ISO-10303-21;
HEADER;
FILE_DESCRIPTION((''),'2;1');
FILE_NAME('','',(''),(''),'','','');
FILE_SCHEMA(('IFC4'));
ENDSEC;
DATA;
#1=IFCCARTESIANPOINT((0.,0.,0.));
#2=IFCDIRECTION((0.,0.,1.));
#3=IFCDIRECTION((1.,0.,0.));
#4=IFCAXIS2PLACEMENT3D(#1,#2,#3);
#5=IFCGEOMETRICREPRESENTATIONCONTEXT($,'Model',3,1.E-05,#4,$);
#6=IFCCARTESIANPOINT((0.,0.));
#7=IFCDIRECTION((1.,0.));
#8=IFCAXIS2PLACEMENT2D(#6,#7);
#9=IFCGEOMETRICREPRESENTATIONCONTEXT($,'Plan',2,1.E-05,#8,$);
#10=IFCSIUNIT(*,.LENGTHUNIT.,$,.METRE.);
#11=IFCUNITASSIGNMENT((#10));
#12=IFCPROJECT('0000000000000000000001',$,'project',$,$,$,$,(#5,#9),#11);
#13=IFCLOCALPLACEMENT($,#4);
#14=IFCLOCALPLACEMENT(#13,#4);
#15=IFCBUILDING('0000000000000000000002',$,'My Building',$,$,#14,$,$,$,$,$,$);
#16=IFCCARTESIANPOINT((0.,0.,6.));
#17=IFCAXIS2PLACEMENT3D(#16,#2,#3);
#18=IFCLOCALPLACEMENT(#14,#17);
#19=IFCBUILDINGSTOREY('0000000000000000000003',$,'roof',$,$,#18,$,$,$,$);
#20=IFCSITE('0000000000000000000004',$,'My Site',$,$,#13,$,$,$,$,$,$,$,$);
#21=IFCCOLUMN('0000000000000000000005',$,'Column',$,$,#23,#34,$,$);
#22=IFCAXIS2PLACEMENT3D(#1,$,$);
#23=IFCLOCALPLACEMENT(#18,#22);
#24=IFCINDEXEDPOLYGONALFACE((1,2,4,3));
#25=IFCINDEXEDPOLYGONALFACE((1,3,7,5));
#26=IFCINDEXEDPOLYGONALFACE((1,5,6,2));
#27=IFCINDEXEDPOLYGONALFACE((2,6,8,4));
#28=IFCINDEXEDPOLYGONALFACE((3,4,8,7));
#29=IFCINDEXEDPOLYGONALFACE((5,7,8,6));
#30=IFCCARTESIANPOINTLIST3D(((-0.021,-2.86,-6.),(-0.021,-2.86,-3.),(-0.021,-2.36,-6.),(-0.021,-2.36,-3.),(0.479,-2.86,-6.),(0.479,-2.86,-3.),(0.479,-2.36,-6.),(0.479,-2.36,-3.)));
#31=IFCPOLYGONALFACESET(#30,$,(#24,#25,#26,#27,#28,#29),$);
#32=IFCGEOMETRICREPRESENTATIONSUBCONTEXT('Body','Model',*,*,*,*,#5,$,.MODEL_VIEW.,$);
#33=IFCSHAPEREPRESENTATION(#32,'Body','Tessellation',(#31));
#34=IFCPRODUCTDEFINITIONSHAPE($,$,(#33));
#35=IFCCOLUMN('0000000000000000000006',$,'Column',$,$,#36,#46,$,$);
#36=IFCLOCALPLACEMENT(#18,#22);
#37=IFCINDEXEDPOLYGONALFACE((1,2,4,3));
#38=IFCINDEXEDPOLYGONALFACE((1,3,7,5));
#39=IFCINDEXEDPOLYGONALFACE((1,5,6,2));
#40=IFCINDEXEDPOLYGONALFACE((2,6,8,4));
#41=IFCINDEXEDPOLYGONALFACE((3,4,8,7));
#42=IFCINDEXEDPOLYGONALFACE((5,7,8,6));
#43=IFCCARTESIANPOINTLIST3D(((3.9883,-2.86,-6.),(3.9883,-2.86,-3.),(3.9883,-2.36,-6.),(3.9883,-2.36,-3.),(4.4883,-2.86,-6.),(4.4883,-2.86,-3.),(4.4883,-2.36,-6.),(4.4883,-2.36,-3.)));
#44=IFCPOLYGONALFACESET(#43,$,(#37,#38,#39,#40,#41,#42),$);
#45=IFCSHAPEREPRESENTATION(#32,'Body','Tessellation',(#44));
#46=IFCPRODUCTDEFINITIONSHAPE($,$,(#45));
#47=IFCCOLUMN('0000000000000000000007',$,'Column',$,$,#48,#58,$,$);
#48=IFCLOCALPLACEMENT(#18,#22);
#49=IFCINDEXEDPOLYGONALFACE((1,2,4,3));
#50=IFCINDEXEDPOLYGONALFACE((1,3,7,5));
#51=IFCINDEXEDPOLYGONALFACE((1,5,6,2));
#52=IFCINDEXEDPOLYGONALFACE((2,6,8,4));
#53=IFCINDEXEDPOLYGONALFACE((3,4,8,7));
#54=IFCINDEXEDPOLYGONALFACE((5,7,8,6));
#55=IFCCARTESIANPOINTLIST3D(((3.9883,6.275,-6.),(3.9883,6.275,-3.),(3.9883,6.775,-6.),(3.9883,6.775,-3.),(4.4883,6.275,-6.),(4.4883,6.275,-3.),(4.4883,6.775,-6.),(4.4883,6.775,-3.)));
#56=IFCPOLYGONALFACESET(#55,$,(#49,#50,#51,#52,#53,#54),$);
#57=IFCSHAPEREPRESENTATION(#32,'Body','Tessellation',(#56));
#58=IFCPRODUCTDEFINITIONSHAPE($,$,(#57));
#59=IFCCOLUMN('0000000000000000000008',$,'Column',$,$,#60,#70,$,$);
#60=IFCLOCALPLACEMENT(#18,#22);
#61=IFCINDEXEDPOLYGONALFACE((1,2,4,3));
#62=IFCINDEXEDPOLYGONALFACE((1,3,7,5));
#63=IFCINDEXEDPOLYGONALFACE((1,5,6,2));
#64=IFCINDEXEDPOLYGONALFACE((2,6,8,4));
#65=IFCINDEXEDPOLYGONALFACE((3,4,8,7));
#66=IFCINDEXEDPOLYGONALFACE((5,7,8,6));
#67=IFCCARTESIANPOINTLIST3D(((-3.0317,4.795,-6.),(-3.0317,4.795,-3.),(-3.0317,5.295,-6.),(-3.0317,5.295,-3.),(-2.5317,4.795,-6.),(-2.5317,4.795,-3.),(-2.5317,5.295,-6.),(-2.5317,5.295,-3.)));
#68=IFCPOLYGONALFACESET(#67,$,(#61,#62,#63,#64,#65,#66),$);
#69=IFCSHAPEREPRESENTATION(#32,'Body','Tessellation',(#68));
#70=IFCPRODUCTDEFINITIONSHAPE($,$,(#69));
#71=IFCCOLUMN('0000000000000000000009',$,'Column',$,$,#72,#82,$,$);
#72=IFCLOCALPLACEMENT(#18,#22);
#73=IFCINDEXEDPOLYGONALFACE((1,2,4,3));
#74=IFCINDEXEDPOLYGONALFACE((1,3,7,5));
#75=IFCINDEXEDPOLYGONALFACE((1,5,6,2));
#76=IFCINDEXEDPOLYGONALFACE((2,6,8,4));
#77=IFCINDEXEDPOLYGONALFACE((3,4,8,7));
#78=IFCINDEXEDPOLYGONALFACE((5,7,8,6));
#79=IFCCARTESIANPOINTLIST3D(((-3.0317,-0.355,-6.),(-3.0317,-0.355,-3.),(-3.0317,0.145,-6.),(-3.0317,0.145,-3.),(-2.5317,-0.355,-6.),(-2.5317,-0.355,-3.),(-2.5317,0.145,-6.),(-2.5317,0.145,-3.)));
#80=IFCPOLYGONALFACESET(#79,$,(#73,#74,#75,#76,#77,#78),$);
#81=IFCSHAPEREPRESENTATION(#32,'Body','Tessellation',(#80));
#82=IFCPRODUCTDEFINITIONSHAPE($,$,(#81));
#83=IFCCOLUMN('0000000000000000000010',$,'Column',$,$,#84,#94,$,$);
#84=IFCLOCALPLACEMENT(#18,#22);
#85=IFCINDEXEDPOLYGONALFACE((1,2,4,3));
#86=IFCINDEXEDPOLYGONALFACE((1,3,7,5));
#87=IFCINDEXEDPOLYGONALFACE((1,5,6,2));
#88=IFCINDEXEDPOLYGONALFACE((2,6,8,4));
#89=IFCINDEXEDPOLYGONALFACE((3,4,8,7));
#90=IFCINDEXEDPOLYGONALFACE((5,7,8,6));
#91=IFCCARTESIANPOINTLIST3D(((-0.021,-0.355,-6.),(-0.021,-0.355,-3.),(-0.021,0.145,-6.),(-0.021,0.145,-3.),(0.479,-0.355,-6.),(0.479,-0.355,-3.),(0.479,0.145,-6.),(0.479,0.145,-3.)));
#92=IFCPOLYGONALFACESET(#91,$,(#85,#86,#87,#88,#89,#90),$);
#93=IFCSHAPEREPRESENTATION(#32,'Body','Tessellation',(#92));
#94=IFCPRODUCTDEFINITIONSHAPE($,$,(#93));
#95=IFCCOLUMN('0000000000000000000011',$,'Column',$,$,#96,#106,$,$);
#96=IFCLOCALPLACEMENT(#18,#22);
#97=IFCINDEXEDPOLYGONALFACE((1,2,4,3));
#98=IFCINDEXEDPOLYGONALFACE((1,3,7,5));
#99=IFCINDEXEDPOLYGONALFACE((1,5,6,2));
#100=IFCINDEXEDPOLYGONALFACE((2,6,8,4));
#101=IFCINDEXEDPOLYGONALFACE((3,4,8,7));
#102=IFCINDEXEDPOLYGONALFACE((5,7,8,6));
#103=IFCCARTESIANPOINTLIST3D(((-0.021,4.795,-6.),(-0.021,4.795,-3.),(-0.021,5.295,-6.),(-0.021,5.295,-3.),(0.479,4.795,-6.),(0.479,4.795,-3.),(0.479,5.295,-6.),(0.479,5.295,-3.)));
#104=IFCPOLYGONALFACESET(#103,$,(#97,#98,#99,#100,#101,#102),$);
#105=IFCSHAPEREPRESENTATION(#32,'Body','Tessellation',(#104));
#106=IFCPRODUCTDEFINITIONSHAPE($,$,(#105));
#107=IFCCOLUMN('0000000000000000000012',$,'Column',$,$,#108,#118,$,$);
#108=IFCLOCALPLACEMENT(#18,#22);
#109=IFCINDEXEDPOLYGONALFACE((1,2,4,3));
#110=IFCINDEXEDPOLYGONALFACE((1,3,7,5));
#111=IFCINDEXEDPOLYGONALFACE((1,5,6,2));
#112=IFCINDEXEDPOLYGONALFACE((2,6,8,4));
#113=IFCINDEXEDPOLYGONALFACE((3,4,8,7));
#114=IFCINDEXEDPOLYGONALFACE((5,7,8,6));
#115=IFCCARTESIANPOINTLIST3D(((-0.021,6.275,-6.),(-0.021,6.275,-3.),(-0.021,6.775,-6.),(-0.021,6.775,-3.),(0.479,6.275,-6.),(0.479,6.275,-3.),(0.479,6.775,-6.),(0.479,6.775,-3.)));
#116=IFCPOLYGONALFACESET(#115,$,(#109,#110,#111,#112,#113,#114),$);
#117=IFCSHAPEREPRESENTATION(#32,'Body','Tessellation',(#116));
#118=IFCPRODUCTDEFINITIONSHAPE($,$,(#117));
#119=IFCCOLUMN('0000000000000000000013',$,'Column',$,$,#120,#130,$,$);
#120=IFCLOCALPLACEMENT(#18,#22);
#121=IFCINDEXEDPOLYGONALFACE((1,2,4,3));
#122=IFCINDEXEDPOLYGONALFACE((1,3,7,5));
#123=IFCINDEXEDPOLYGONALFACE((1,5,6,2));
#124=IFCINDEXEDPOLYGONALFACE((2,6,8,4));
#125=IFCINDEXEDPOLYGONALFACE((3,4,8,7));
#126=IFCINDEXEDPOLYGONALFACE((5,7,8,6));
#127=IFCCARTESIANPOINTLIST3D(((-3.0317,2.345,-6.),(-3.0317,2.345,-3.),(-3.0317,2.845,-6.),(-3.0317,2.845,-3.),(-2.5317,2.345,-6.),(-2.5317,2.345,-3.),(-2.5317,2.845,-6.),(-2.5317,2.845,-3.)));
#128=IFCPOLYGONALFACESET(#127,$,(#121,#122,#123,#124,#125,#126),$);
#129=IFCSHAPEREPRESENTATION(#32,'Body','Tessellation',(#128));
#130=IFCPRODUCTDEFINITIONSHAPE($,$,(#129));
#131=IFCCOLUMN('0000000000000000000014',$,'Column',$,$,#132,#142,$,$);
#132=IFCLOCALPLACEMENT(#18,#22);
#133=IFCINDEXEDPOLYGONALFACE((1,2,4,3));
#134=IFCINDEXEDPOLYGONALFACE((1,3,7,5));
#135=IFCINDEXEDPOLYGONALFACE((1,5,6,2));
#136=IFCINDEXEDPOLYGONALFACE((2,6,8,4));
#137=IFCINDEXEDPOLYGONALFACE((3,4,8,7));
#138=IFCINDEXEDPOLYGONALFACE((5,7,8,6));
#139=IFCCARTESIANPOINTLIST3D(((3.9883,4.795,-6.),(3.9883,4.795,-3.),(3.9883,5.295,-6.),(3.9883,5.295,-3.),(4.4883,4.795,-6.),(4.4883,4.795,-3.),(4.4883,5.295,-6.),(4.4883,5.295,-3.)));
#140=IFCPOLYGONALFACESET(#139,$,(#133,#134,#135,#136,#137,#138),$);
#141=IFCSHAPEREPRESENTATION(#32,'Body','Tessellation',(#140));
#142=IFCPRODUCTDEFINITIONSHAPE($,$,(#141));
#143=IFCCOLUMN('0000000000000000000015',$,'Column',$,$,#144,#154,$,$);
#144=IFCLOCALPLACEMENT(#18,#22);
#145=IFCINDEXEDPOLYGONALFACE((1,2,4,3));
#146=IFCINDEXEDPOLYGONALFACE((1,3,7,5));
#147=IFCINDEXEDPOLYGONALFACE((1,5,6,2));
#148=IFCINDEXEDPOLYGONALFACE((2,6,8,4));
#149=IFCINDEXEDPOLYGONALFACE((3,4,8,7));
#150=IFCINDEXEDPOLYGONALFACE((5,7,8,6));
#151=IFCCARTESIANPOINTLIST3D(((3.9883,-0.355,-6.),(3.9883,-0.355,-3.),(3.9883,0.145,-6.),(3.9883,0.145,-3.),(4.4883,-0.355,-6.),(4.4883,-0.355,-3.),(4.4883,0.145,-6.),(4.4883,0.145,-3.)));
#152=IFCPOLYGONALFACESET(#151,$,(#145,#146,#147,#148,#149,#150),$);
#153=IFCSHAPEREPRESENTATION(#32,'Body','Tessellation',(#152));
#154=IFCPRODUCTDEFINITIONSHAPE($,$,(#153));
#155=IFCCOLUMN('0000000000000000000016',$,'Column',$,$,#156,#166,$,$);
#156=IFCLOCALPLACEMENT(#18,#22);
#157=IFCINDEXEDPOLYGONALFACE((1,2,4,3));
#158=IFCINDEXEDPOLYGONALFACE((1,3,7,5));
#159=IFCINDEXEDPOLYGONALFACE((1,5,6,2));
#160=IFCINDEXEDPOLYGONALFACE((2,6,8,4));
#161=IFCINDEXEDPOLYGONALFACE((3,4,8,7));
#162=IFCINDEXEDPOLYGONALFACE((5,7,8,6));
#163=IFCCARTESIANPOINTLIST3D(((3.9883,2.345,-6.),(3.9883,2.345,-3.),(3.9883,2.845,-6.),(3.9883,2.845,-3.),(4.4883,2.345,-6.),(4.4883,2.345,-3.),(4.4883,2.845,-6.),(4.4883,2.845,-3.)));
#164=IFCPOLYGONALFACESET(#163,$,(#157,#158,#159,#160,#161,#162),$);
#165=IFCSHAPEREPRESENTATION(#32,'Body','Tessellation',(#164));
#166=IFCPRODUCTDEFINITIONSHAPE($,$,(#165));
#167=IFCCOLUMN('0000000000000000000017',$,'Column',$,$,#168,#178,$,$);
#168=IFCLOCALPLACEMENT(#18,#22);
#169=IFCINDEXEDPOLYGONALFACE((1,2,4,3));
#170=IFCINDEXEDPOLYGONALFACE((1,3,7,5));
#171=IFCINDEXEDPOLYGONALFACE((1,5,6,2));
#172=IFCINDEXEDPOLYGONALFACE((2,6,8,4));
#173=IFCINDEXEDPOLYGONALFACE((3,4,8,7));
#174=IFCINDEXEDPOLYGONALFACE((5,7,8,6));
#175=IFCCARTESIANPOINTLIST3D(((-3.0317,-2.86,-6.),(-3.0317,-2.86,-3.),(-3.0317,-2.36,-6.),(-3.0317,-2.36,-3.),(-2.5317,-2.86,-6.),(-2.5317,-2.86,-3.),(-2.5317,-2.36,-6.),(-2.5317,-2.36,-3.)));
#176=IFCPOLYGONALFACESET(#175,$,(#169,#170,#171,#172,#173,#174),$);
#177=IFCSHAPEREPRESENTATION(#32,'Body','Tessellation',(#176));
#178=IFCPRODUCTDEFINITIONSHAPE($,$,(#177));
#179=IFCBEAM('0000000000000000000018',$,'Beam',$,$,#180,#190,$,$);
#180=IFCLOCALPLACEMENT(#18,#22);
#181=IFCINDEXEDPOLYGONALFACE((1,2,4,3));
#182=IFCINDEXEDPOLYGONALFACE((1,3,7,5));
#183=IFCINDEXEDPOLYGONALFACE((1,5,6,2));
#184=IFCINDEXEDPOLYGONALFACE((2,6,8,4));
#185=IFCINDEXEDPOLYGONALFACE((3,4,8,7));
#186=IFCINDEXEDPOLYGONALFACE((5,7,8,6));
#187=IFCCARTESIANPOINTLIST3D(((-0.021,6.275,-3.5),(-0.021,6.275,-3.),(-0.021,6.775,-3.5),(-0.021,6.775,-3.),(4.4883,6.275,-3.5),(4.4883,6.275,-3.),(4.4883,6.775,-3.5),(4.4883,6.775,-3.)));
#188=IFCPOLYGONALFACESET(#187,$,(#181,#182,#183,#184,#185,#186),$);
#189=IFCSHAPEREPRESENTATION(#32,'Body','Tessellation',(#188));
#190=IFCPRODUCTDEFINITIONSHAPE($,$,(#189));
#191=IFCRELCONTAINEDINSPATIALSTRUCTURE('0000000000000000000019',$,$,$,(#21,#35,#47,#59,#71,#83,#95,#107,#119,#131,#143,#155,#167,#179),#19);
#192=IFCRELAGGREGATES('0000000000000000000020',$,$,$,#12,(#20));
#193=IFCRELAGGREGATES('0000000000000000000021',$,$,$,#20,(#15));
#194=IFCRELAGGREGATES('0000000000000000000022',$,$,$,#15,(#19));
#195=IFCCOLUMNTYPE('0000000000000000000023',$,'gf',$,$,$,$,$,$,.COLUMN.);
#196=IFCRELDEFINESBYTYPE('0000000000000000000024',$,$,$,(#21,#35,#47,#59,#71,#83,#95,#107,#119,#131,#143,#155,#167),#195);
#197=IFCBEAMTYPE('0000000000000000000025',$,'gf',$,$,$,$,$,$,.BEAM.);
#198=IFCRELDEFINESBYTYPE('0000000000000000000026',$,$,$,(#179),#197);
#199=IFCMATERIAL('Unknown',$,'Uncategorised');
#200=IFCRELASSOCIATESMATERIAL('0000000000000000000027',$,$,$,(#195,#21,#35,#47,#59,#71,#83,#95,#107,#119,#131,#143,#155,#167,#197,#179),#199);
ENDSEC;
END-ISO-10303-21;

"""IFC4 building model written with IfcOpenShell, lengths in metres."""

from ifc_helpers import new_model, si_unit, frame, origin_with_axes, origin_2d_with_axis, place, context, subcontext, project, spatial, rectangle, extrude, material, material_profile, profile_set, profile_usage, type_object, element, save


model = new_model("IFC4")

# Units and contexts
model_context = context("Model", 3, precision=1e-05, world=origin_with_axes())
plan_context = context("Plan", 2, precision=1e-05, world=origin_2d_with_axis())
body_context = subcontext(model_context, "Body", "Model", "MODEL_VIEW")
ifc_project = project(units=[si_unit("LENGTHUNIT", "METRE")], contexts=[model_context, plan_context])

# Site, building, storey
site_placement = place(None, origin_with_axes())
site = spatial("IfcSite", under=ifc_project, at=site_placement, Name="My Site")
building_placement = place(site_placement, origin_with_axes())
building = spatial("IfcBuilding", under=site, at=building_placement, Name="My Building")
storey_placement = place(building_placement, frame((0.0, 0.0, 6.0), z_axis=(0.0, 0.0, 1.0), x_axis=(1.0, 0.0, 0.0)))
storey = spatial("IfcBuildingStorey", under=building, at=storey_placement, Name="roof")

# Columns
ifc_material = material(Name="Unknown", Category="Uncategorised")
ifc_material_profile_1 = material_profile(ifc_material, rectangle(XDim=0.5, YDim=0.5))
ifc_profile_set_1 = profile_set([ifc_material_profile_1])
ifc_profile_usage_1 = profile_usage(ifc_profile_set_1, cardinal=5)
column_type = type_object("IfcColumnType", Name="gf", PredefinedType="COLUMN", material=ifc_profile_set_1)
column_1_placement = place(storey_placement, frame((0.229, -2.61, -6.0), z_axis=(0.0, 0.0, 1.0), x_axis=(1.0, 0.0, 0.0)))
element("IfcColumn", 1, at=column_1_placement, inside=storey, type_object=column_type, material=ifc_profile_usage_1, Name="Column", context=body_context, shape_type="SweptSolid", body=[
    extrude(rectangle(XDim=0.5, YDim=0.5), origin_with_axes(), (0.0, 0.0, 1.0), 3.0),
])
ifc_profile_usage_2 = profile_usage(ifc_profile_set_1, cardinal=5)
column_2_placement = place(storey_placement, frame((4.2383, -2.61, -6.0), z_axis=(0.0, 0.0, 1.0), x_axis=(1.0, 0.0, 0.0)))
element("IfcColumn", 2, at=column_2_placement, inside=storey, type_object=column_type, material=ifc_profile_usage_2, Name="Column", context=body_context, shape_type="SweptSolid", body=[
    extrude(rectangle(XDim=0.5, YDim=0.5), origin_with_axes(), (0.0, 0.0, 1.0), 3.0),
])
ifc_profile_usage_3 = profile_usage(ifc_profile_set_1, cardinal=5)
column_3_placement = place(storey_placement, frame((4.2383, 6.525, -6.0), z_axis=(0.0, 0.0, 1.0), x_axis=(1.0, 0.0, 0.0)))
element("IfcColumn", 3, at=column_3_placement, inside=storey, type_object=column_type, material=ifc_profile_usage_3, Name="Column", context=body_context, shape_type="SweptSolid", body=[
    extrude(rectangle(XDim=0.5, YDim=0.5), origin_with_axes(), (0.0, 0.0, 1.0), 3.0),
])
ifc_profile_usage_4 = profile_usage(ifc_profile_set_1, cardinal=5)
column_4_placement = place(storey_placement, frame((-2.7817, 5.045, -6.0), z_axis=(0.0, 0.0, 1.0), x_axis=(1.0, 0.0, 0.0)))
element("IfcColumn", 4, at=column_4_placement, inside=storey, type_object=column_type, material=ifc_profile_usage_4, Name="Column", context=body_context, shape_type="SweptSolid", body=[
    extrude(rectangle(XDim=0.5, YDim=0.5), origin_with_axes(), (0.0, 0.0, 1.0), 3.0),
])
ifc_profile_usage_5 = profile_usage(ifc_profile_set_1, cardinal=5)
column_5_placement = place(storey_placement, frame((-2.7817, -0.105, -6.0), z_axis=(0.0, 0.0, 1.0), x_axis=(1.0, 0.0, 0.0)))
element("IfcColumn", 5, at=column_5_placement, inside=storey, type_object=column_type, material=ifc_profile_usage_5, Name="Column", context=body_context, shape_type="SweptSolid", body=[
    extrude(rectangle(XDim=0.5, YDim=0.5), origin_with_axes(), (0.0, 0.0, 1.0), 3.0),
])
ifc_profile_usage_6 = profile_usage(ifc_profile_set_1, cardinal=5)
column_6_placement = place(storey_placement, frame((0.229, -0.105, -6.0), z_axis=(0.0, 0.0, 1.0), x_axis=(1.0, 0.0, 0.0)))
element("IfcColumn", 6, at=column_6_placement, inside=storey, type_object=column_type, material=ifc_profile_usage_6, Name="Column", context=body_context, shape_type="SweptSolid", body=[
    extrude(rectangle(XDim=0.5, YDim=0.5), origin_with_axes(), (0.0, 0.0, 1.0), 3.0),
])
ifc_profile_usage_7 = profile_usage(ifc_profile_set_1, cardinal=5)
column_7_placement = place(storey_placement, frame((0.229, 5.045, -6.0), z_axis=(0.0, 0.0, 1.0), x_axis=(1.0, 0.0, 0.0)))
element("IfcColumn", 7, at=column_7_placement, inside=storey, type_object=column_type, material=ifc_profile_usage_7, Name="Column", context=body_context, shape_type="SweptSolid", body=[
    extrude(rectangle(XDim=0.5, YDim=0.5), origin_with_axes(), (0.0, 0.0, 1.0), 3.0),
])
ifc_profile_usage_8 = profile_usage(ifc_profile_set_1, cardinal=5)
column_8_placement = place(storey_placement, frame((0.229, 6.525, -6.0), z_axis=(0.0, 0.0, 1.0), x_axis=(1.0, 0.0, 0.0)))
element("IfcColumn", 8, at=column_8_placement, inside=storey, type_object=column_type, material=ifc_profile_usage_8, Name="Column", context=body_context, shape_type="SweptSolid", body=[
    extrude(rectangle(XDim=0.5, YDim=0.5), origin_with_axes(), (0.0, 0.0, 1.0), 3.0),
])
ifc_profile_usage_9 = profile_usage(ifc_profile_set_1, cardinal=5)
column_9_placement = place(storey_placement, frame((-2.7817, 2.595, -6.0), z_axis=(0.0, 0.0, 1.0), x_axis=(1.0, 0.0, 0.0)))
element("IfcColumn", 9, at=column_9_placement, inside=storey, type_object=column_type, material=ifc_profile_usage_9, Name="Column", context=body_context, shape_type="SweptSolid", body=[
    extrude(rectangle(XDim=0.5, YDim=0.5), origin_with_axes(), (0.0, 0.0, 1.0), 3.0),
])
ifc_profile_usage_10 = profile_usage(ifc_profile_set_1, cardinal=5)
column_10_placement = place(storey_placement, frame((4.2383, 5.045, -6.0), z_axis=(0.0, 0.0, 1.0), x_axis=(1.0, 0.0, 0.0)))
element("IfcColumn", 10, at=column_10_placement, inside=storey, type_object=column_type, material=ifc_profile_usage_10, Name="Column", context=body_context, shape_type="SweptSolid", body=[
    extrude(rectangle(XDim=0.5, YDim=0.5), origin_with_axes(), (0.0, 0.0, 1.0), 3.0),
])
ifc_profile_usage_11 = profile_usage(ifc_profile_set_1, cardinal=5)
column_11_placement = place(storey_placement, frame((4.2383, -0.105, -6.0), z_axis=(0.0, 0.0, 1.0), x_axis=(1.0, 0.0, 0.0)))
element("IfcColumn", 11, at=column_11_placement, inside=storey, type_object=column_type, material=ifc_profile_usage_11, Name="Column", context=body_context, shape_type="SweptSolid", body=[
    extrude(rectangle(XDim=0.5, YDim=0.5), origin_with_axes(), (0.0, 0.0, 1.0), 3.0),
])
ifc_profile_usage_12 = profile_usage(ifc_profile_set_1, cardinal=5)
column_12_placement = place(storey_placement, frame((4.2383, 2.595, -6.0), z_axis=(0.0, 0.0, 1.0), x_axis=(1.0, 0.0, 0.0)))
element("IfcColumn", 12, at=column_12_placement, inside=storey, type_object=column_type, material=ifc_profile_usage_12, Name="Column", context=body_context, shape_type="SweptSolid", body=[
    extrude(rectangle(XDim=0.5, YDim=0.5), origin_with_axes(), (0.0, 0.0, 1.0), 3.0),
])
ifc_profile_usage_13 = profile_usage(ifc_profile_set_1, cardinal=5)
column_13_placement = place(storey_placement, frame((-2.7817, -2.61, -6.0), z_axis=(0.0, 0.0, 1.0), x_axis=(1.0, 0.0, 0.0)))
element("IfcColumn", 13, at=column_13_placement, inside=storey, type_object=column_type, material=ifc_profile_usage_13, Name="Column", context=body_context, shape_type="SweptSolid", body=[
    extrude(rectangle(XDim=0.5, YDim=0.5), origin_with_axes(), (0.0, 0.0, 1.0), 3.0),
])

# Beam
ifc_material_profile_2 = material_profile(ifc_material, rectangle(XDim=0.5, YDim=0.5))
ifc_profile_set_2 = profile_set([ifc_material_profile_2])
ifc_profile_usage_14 = profile_usage(ifc_profile_set_2, cardinal=7)
beam_type = type_object("IfcBeamType", Name="gf", PredefinedType="BEAM", material=ifc_profile_set_2)
beam_1_placement = place(storey_placement, frame((-0.021, 6.775, -3.0), z_axis=(1.0, -0.000001, 0.000001), x_axis=(0.000001, 1.0, 0.0)))
element("IfcBeam", 14, at=beam_1_placement, inside=storey, type_object=beam_type, material=ifc_profile_usage_14, Name="Beam", context=body_context, shape_type="SweptSolid", body=[
    extrude(rectangle(XDim=0.5, YDim=0.5), frame((-0.25, -0.25, 0.0), z_axis=(0.0, 0.0, 1.0), x_axis=(1.0, 0.0, 0.0)), (0.0, 0.0, 1.0), 4.5094),
])

save(model, "model.ifc")
